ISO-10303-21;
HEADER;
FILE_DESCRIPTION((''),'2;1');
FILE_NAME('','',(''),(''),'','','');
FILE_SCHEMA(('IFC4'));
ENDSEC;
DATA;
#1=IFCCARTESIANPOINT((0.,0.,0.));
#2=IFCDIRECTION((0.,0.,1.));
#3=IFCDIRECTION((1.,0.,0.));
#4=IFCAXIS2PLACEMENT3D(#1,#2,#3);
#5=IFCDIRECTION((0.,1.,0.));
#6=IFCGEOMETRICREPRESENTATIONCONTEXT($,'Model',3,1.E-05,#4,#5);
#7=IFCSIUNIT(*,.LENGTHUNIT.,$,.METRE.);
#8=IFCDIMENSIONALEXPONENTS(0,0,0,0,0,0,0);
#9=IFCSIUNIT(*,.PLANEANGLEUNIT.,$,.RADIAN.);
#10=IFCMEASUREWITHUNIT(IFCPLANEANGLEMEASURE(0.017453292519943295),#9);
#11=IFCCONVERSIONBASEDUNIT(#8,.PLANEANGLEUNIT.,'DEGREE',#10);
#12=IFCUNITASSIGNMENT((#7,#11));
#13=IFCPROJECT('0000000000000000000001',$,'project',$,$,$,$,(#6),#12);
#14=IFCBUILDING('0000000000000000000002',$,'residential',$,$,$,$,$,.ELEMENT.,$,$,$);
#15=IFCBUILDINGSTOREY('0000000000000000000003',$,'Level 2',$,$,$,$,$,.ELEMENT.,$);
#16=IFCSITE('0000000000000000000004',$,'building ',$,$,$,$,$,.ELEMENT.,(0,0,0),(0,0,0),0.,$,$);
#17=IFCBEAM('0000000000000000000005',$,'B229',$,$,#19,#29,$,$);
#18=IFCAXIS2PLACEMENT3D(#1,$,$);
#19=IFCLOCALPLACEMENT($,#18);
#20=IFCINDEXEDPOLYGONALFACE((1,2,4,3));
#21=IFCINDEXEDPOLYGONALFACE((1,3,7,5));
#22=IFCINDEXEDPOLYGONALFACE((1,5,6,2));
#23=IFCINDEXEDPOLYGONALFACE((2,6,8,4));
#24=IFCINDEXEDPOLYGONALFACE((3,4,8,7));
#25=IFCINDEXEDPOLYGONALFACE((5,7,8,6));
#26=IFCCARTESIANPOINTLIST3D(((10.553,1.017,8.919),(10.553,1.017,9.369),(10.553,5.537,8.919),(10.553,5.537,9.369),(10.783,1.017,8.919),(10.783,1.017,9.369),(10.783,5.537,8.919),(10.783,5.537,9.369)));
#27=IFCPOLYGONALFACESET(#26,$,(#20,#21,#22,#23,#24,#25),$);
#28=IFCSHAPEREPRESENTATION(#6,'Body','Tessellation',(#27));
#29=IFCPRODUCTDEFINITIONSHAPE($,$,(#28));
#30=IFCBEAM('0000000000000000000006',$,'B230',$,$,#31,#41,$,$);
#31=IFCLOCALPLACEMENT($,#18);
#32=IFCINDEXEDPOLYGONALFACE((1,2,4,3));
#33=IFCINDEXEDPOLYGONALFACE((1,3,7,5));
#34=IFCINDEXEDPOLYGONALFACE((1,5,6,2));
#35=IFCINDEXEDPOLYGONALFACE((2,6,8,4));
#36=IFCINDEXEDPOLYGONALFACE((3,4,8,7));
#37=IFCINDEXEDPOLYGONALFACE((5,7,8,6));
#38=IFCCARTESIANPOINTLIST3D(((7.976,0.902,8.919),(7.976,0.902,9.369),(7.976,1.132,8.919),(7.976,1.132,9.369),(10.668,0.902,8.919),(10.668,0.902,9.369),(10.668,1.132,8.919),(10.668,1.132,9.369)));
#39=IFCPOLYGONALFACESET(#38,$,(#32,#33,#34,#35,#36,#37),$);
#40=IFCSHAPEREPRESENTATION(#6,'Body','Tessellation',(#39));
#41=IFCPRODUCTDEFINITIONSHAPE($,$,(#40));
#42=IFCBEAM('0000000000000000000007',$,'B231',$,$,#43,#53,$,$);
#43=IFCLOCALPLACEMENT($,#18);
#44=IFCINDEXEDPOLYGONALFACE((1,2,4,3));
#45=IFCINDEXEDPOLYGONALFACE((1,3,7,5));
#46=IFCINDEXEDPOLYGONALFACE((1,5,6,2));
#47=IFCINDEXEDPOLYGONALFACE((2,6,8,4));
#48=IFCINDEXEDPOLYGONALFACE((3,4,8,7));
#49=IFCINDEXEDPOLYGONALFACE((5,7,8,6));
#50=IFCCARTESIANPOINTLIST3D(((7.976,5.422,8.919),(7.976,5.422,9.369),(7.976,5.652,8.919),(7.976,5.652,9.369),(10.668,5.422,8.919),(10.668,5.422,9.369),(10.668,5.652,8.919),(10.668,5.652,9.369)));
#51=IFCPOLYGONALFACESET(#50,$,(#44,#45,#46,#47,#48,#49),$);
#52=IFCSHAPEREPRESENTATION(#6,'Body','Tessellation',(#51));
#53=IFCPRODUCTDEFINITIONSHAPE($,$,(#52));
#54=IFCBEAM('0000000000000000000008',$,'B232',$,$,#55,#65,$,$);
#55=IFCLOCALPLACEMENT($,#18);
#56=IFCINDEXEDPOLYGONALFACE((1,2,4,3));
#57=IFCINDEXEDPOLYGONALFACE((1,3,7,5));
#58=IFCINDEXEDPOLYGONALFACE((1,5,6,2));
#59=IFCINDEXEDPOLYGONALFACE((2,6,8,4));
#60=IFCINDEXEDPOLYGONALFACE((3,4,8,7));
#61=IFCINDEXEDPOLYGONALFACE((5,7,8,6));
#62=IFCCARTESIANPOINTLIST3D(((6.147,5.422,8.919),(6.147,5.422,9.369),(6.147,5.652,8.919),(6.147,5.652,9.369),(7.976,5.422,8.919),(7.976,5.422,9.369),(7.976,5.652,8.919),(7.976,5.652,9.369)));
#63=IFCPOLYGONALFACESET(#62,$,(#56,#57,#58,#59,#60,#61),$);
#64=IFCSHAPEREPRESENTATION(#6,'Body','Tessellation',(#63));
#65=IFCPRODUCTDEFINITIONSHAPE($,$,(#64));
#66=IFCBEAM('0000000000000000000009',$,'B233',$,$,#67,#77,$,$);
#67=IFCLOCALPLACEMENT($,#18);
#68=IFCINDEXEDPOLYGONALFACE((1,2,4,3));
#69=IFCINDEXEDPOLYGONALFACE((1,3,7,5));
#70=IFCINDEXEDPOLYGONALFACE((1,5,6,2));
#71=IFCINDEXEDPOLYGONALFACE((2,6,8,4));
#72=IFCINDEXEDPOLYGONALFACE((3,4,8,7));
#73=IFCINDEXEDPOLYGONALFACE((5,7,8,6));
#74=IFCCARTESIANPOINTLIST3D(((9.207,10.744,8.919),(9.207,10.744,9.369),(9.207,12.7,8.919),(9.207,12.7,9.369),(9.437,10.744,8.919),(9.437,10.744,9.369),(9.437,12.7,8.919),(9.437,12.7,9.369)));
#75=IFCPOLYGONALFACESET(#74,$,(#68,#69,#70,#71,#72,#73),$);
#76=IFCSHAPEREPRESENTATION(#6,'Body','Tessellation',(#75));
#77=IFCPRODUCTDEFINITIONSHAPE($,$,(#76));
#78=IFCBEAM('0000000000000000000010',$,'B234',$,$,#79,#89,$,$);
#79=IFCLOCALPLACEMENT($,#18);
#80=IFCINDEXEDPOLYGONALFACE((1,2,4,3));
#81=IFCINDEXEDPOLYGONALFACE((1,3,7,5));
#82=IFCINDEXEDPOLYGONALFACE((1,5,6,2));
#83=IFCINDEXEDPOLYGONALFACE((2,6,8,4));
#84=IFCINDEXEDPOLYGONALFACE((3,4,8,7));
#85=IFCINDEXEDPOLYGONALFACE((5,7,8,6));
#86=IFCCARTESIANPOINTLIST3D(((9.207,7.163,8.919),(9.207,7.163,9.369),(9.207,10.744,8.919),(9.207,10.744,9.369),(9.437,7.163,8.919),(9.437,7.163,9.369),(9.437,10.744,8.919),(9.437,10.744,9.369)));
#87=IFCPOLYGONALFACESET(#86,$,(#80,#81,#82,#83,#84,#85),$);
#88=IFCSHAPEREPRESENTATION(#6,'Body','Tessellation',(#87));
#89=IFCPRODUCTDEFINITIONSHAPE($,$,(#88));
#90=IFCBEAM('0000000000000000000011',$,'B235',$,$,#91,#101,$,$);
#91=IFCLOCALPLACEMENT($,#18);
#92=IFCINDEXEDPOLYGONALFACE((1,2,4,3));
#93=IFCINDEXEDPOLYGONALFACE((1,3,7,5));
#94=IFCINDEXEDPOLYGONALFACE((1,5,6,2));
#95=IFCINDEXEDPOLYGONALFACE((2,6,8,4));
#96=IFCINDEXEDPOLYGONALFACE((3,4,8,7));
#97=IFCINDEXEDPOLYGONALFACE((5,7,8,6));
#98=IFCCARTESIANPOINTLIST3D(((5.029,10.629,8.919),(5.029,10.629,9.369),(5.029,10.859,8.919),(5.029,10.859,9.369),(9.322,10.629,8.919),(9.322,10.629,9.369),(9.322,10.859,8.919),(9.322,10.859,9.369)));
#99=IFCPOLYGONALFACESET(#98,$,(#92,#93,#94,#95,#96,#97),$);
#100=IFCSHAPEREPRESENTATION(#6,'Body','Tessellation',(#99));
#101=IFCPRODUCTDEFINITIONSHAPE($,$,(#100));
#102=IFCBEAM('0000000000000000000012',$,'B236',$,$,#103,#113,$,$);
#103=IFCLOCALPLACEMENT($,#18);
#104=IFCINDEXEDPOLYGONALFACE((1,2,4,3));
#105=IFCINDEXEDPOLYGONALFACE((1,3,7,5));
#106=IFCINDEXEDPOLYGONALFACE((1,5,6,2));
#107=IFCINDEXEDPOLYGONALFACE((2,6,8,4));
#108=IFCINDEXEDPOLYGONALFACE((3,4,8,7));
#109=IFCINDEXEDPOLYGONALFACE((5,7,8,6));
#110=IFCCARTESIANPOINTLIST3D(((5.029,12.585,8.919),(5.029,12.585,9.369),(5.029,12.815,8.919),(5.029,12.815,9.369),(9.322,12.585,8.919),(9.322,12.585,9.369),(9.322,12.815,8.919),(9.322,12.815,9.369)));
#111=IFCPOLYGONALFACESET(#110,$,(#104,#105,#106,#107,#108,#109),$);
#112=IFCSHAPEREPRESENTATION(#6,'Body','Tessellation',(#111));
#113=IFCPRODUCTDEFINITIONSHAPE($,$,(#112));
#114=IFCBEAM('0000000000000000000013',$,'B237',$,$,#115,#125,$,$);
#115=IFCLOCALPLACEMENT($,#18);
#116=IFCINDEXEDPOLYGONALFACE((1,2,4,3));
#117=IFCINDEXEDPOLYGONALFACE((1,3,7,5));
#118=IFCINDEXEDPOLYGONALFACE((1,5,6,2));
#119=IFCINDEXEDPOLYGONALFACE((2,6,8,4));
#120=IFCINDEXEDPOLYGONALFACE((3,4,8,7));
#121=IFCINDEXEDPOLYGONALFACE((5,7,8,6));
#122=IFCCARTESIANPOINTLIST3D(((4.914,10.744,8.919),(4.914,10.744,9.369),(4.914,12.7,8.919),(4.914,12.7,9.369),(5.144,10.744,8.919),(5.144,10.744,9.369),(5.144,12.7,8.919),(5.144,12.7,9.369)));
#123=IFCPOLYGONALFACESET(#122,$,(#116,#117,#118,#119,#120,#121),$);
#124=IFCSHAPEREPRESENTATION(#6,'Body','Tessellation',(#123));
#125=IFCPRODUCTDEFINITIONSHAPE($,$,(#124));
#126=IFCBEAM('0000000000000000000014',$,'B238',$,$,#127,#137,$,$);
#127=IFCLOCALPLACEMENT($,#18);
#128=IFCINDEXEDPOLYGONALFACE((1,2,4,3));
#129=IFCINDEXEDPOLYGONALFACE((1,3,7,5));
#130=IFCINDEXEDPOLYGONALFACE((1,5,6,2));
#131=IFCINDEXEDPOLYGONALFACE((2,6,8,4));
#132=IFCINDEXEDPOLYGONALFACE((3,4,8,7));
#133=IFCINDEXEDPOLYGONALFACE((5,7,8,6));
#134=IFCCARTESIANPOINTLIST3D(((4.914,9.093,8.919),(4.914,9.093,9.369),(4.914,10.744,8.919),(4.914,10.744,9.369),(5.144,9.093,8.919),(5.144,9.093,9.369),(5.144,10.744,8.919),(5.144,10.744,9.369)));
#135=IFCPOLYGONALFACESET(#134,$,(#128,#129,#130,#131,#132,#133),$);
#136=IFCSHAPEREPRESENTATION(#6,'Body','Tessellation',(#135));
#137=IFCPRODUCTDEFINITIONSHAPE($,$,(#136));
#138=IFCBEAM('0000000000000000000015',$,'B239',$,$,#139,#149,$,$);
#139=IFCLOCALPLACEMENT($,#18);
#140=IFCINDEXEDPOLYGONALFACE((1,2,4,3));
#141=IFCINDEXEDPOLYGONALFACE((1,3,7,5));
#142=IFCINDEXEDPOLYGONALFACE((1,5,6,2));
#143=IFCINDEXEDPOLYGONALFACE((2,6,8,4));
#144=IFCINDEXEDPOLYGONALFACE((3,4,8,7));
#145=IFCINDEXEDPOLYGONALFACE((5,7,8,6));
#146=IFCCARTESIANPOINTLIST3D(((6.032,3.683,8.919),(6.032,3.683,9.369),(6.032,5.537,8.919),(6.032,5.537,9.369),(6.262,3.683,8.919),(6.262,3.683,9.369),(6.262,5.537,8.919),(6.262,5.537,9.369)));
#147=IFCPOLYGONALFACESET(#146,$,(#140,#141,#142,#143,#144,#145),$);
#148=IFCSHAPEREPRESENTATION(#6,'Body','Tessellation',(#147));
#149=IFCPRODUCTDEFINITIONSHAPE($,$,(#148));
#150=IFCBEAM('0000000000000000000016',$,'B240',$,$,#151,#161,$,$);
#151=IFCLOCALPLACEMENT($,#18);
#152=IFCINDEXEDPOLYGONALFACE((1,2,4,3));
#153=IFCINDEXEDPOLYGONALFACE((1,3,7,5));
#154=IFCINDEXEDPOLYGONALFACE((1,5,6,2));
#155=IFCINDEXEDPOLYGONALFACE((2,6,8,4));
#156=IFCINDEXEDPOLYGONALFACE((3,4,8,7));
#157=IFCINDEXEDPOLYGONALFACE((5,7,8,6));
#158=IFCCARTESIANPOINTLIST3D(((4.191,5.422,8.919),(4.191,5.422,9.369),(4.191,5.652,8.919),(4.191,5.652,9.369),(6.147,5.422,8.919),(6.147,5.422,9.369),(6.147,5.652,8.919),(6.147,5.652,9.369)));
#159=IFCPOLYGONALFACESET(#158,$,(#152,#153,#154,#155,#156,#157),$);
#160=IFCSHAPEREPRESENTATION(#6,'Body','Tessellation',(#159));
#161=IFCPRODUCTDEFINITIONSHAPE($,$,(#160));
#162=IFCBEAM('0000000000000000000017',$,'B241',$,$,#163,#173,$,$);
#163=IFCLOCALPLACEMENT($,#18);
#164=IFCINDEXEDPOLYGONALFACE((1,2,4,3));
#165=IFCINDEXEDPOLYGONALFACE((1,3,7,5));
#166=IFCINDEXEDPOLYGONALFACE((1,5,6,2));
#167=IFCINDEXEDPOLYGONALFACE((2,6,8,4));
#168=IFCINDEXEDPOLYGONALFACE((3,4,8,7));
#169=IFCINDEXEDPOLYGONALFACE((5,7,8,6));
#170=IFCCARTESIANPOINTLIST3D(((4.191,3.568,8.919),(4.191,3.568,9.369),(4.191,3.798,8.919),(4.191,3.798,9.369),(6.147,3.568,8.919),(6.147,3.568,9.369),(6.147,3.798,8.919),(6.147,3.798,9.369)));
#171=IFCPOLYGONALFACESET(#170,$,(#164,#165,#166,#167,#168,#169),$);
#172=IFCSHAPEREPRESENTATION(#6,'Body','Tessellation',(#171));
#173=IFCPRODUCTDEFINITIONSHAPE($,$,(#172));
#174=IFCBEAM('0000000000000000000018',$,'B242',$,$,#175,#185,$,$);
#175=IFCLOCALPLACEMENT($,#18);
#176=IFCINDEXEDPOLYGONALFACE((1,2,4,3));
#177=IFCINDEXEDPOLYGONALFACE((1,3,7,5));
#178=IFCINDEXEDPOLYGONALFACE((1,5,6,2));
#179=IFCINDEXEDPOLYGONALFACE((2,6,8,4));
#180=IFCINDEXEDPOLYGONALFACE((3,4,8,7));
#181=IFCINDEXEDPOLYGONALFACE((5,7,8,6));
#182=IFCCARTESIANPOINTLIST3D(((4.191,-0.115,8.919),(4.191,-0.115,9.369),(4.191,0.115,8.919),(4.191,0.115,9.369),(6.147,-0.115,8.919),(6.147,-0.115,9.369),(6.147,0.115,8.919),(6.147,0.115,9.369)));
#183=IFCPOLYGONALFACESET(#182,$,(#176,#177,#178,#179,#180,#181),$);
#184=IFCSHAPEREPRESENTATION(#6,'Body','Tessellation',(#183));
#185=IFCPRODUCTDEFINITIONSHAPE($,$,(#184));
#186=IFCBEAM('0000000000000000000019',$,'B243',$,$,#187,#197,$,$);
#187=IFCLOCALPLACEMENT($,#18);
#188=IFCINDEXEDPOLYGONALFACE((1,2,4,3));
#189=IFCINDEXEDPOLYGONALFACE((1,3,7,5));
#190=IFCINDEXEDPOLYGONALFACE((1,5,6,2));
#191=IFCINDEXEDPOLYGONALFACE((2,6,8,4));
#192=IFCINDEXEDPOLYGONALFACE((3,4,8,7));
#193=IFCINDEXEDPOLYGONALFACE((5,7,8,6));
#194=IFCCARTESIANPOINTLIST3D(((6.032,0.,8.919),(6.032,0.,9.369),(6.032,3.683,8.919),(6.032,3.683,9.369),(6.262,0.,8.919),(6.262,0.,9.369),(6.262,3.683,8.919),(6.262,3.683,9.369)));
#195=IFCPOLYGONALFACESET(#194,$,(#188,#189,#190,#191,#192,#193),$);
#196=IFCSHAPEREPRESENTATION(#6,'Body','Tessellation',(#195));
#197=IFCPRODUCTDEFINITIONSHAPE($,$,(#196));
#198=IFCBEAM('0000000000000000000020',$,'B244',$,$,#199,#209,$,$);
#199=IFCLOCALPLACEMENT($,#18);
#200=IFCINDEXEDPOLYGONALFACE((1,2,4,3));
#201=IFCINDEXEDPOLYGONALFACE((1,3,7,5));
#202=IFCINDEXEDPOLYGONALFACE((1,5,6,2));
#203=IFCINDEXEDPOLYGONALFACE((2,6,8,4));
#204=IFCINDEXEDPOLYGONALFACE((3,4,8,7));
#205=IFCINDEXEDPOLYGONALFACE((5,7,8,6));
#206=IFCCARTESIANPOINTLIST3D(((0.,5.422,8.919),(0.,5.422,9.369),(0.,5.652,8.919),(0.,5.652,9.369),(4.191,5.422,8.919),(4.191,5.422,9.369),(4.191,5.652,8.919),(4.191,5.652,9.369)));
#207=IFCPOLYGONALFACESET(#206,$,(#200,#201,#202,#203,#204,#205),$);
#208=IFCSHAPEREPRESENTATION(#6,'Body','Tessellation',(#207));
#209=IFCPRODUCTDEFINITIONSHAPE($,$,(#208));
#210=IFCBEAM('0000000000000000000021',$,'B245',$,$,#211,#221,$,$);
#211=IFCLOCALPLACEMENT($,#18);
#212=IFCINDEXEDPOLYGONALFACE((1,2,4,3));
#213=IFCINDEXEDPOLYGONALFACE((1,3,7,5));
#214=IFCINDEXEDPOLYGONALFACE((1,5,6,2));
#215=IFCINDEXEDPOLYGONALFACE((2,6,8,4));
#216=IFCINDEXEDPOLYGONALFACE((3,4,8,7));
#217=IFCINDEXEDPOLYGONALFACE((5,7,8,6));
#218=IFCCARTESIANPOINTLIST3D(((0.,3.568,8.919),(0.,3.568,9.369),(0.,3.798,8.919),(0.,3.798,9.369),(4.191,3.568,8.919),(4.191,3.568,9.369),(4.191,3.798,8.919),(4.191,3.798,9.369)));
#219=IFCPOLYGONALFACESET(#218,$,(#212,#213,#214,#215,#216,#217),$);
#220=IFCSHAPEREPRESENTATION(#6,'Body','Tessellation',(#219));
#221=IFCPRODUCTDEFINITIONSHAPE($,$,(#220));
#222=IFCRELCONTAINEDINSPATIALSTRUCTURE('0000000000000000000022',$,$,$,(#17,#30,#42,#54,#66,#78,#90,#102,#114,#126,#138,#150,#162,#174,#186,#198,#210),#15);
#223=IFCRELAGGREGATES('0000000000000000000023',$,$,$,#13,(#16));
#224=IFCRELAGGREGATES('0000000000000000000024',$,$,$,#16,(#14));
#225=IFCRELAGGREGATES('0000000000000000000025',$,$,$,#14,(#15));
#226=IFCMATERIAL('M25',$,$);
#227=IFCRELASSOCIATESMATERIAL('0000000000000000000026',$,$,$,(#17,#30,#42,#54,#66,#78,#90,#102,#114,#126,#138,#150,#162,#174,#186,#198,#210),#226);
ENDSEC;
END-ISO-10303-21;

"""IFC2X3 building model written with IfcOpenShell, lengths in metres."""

from ifc_helpers import new_model, entity, si_unit, converted_unit, direction, frame, frame_2d, origin_with_axes, place, context, project, spatial, rectangle, extrude, material, element, save


model = new_model("IFC2X3")

# Units and contexts
model_context = context("Model", 3, precision=1e-05, world=origin_with_axes(), true_north=direction((0.0, 1.0, 0.0)))
ifc_project = project(units=[si_unit("LENGTHUNIT", "METRE"), converted_unit("PLANEANGLEUNIT", "DEGREE", entity("IfcPlaneAngleMeasure", 0.017453292519943295), si_unit("PLANEANGLEUNIT", "RADIAN"), dimensions=[0, 0, 0, 0, 0, 0, 0])], contexts=[model_context])

# Site, building, storey
site = spatial("IfcSite", under=ifc_project, Name="building ", CompositionType="ELEMENT", RefLatitude=(0, 0, 0), RefLongitude=(0, 0, 0), RefElevation=0.0)
building = spatial("IfcBuilding", under=site, Name="residential", CompositionType="ELEMENT")
storey = spatial("IfcBuildingStorey", under=building, Name="Level 2", CompositionType="ELEMENT")

# Beams
ifc_material = material(Name="M25")
placement = place(None, origin_with_axes())
element("IfcBeam", 1, at=placement, inside=storey, material=ifc_material, Name="B229", context=model_context, shape_type="SweptSolid", body=[
    extrude(rectangle(XDim=0.23, YDim=0.45, at=frame_2d((0.0, 0.0), x_axis=(0.0, 1.0, 0.0))), frame((10.668, 1.017, 9.144), z_axis=(0.0, 1.0, 0.0), x_axis=(0.0, 0.0, -1.0)), (0.0, 0.0, 1.0), 4.52),
])
element("IfcBeam", 2, at=placement, inside=storey, material=ifc_material, Name="B230", context=model_context, shape_type="SweptSolid", body=[
    extrude(rectangle(XDim=0.23, YDim=0.45, at=frame_2d((0.0, 0.0), x_axis=(0.0, 1.0, 0.0))), frame((7.976, 1.017, 9.144), z_axis=(1.0, 0.0, 0.0), x_axis=(0.0, 0.0, -1.0)), (0.0, 0.0, 1.0), 2.692),
])
element("IfcBeam", 3, at=placement, inside=storey, material=ifc_material, Name="B231", context=model_context, shape_type="SweptSolid", body=[
    extrude(rectangle(XDim=0.23, YDim=0.45, at=frame_2d((0.0, 0.0), x_axis=(0.0, 1.0, 0.0))), frame((7.976, 5.537, 9.144), z_axis=(1.0, 0.0, 0.0), x_axis=(0.0, 0.0, -1.0)), (0.0, 0.0, 1.0), 2.692),
])
element("IfcBeam", 4, at=placement, inside=storey, material=ifc_material, Name="B232", context=model_context, shape_type="SweptSolid", body=[
    extrude(rectangle(XDim=0.23, YDim=0.45, at=frame_2d((0.0, 0.0), x_axis=(0.0, 1.0, 0.0))), frame((6.147, 5.537, 9.144), z_axis=(1.0, 0.0, 0.0), x_axis=(0.0, 0.0, -1.0)), (0.0, 0.0, 1.0), 1.829),
])
element("IfcBeam", 5, at=placement, inside=storey, material=ifc_material, Name="B233", context=model_context, shape_type="SweptSolid", body=[
    extrude(rectangle(XDim=0.23, YDim=0.45, at=frame_2d((0.0, 0.0), x_axis=(0.0, 1.0, 0.0))), frame((9.322, 10.744, 9.144), z_axis=(0.0, 1.0, 0.0), x_axis=(0.0, 0.0, -1.0)), (0.0, 0.0, 1.0), 1.956),
])
element("IfcBeam", 6, at=placement, inside=storey, material=ifc_material, Name="B234", context=model_context, shape_type="SweptSolid", body=[
    extrude(rectangle(XDim=0.23, YDim=0.45, at=frame_2d((0.0, 0.0), x_axis=(0.0, 1.0, 0.0))), frame((9.322, 7.163, 9.144), z_axis=(0.0, 1.0, 0.0), x_axis=(0.0, 0.0, -1.0)), (0.0, 0.0, 1.0), 3.581),
])
element("IfcBeam", 7, at=placement, inside=storey, material=ifc_material, Name="B235", context=model_context, shape_type="SweptSolid", body=[
    extrude(rectangle(XDim=0.23, YDim=0.45, at=frame_2d((0.0, 0.0), x_axis=(0.0, 1.0, 0.0))), frame((5.029, 10.744, 9.144), z_axis=(1.0, 0.0, 0.0), x_axis=(0.0, 0.0, -1.0)), (0.0, 0.0, 1.0), 4.293),
])
element("IfcBeam", 8, at=placement, inside=storey, material=ifc_material, Name="B236", context=model_context, shape_type="SweptSolid", body=[
    extrude(rectangle(XDim=0.23, YDim=0.45, at=frame_2d((0.0, 0.0), x_axis=(0.0, 1.0, 0.0))), frame((5.029, 12.7, 9.144), z_axis=(1.0, 0.0, 0.0), x_axis=(0.0, 0.0, -1.0)), (0.0, 0.0, 1.0), 4.293),
])
element("IfcBeam", 9, at=placement, inside=storey, material=ifc_material, Name="B237", context=model_context, shape_type="SweptSolid", body=[
    extrude(rectangle(XDim=0.23, YDim=0.45, at=frame_2d((0.0, 0.0), x_axis=(0.0, 1.0, 0.0))), frame((5.029, 10.744, 9.144), z_axis=(0.0, 1.0, 0.0), x_axis=(0.0, 0.0, -1.0)), (0.0, 0.0, 1.0), 1.956),
])
element("IfcBeam", 10, at=placement, inside=storey, material=ifc_material, Name="B238", context=model_context, shape_type="SweptSolid", body=[
    extrude(rectangle(XDim=0.23, YDim=0.45, at=frame_2d((0.0, 0.0), x_axis=(0.0, 1.0, 0.0))), frame((5.029, 9.093, 9.144), z_axis=(0.0, 1.0, 0.0), x_axis=(0.0, 0.0, -1.0)), (0.0, 0.0, 1.0), 1.651),
])
element("IfcBeam", 11, at=placement, inside=storey, material=ifc_material, Name="B239", context=model_context, shape_type="SweptSolid", body=[
    extrude(rectangle(XDim=0.23, YDim=0.45, at=frame_2d((0.0, 0.0), x_axis=(0.0, 1.0, 0.0))), frame((6.147, 3.683, 9.144), z_axis=(0.0, 1.0, 0.0), x_axis=(0.0, 0.0, -1.0)), (0.0, 0.0, 1.0), 1.854),
])
element("IfcBeam", 12, at=placement, inside=storey, material=ifc_material, Name="B240", context=model_context, shape_type="SweptSolid", body=[
    extrude(rectangle(XDim=0.23, YDim=0.45, at=frame_2d((0.0, 0.0), x_axis=(0.0, 1.0, 0.0))), frame((4.191, 5.537, 9.144), z_axis=(1.0, 0.0, 0.0), x_axis=(0.0, 0.0, -1.0)), (0.0, 0.0, 1.0), 1.956),
])
element("IfcBeam", 13, at=placement, inside=storey, material=ifc_material, Name="B241", context=model_context, shape_type="SweptSolid", body=[
    extrude(rectangle(XDim=0.23, YDim=0.45, at=frame_2d((0.0, 0.0), x_axis=(0.0, 1.0, 0.0))), frame((4.191, 3.683, 9.144), z_axis=(1.0, 0.0, 0.0), x_axis=(0.0, 0.0, -1.0)), (0.0, 0.0, 1.0), 1.956),
])
element("IfcBeam", 14, at=placement, inside=storey, material=ifc_material, Name="B242", context=model_context, shape_type="SweptSolid", body=[
    extrude(rectangle(XDim=0.23, YDim=0.45, at=frame_2d((0.0, 0.0), x_axis=(0.0, 1.0, 0.0))), frame((4.191, 0.0, 9.144), z_axis=(1.0, 0.0, 0.0), x_axis=(0.0, 0.0, -1.0)), (0.0, 0.0, 1.0), 1.956),
])
element("IfcBeam", 15, at=placement, inside=storey, material=ifc_material, Name="B243", context=model_context, shape_type="SweptSolid", body=[
    extrude(rectangle(XDim=0.23, YDim=0.45, at=frame_2d((0.0, 0.0), x_axis=(0.0, 1.0, 0.0))), frame((6.147, 0.0, 9.144), z_axis=(0.0, 1.0, 0.0), x_axis=(0.0, 0.0, -1.0)), (0.0, 0.0, 1.0), 3.683),
])
element("IfcBeam", 16, at=placement, inside=storey, material=ifc_material, Name="B244", context=model_context, shape_type="SweptSolid", body=[
    extrude(rectangle(XDim=0.23, YDim=0.45, at=frame_2d((0.0, 0.0), x_axis=(0.0, 1.0, 0.0))), frame((0.0, 5.537, 9.144), z_axis=(1.0, 0.0, 0.0), x_axis=(0.0, 0.0, -1.0)), (0.0, 0.0, 1.0), 4.191),
])
element("IfcBeam", 17, at=placement, inside=storey, material=ifc_material, Name="B245", context=model_context, shape_type="SweptSolid", body=[
    extrude(rectangle(XDim=0.23, YDim=0.45, at=frame_2d((0.0, 0.0), x_axis=(0.0, 1.0, 0.0))), frame((0.0, 3.683, 9.144), z_axis=(1.0, 0.0, 0.0), x_axis=(0.0, 0.0, -1.0)), (0.0, 0.0, 1.0), 4.191),
])

save(model, "model.ifc")
